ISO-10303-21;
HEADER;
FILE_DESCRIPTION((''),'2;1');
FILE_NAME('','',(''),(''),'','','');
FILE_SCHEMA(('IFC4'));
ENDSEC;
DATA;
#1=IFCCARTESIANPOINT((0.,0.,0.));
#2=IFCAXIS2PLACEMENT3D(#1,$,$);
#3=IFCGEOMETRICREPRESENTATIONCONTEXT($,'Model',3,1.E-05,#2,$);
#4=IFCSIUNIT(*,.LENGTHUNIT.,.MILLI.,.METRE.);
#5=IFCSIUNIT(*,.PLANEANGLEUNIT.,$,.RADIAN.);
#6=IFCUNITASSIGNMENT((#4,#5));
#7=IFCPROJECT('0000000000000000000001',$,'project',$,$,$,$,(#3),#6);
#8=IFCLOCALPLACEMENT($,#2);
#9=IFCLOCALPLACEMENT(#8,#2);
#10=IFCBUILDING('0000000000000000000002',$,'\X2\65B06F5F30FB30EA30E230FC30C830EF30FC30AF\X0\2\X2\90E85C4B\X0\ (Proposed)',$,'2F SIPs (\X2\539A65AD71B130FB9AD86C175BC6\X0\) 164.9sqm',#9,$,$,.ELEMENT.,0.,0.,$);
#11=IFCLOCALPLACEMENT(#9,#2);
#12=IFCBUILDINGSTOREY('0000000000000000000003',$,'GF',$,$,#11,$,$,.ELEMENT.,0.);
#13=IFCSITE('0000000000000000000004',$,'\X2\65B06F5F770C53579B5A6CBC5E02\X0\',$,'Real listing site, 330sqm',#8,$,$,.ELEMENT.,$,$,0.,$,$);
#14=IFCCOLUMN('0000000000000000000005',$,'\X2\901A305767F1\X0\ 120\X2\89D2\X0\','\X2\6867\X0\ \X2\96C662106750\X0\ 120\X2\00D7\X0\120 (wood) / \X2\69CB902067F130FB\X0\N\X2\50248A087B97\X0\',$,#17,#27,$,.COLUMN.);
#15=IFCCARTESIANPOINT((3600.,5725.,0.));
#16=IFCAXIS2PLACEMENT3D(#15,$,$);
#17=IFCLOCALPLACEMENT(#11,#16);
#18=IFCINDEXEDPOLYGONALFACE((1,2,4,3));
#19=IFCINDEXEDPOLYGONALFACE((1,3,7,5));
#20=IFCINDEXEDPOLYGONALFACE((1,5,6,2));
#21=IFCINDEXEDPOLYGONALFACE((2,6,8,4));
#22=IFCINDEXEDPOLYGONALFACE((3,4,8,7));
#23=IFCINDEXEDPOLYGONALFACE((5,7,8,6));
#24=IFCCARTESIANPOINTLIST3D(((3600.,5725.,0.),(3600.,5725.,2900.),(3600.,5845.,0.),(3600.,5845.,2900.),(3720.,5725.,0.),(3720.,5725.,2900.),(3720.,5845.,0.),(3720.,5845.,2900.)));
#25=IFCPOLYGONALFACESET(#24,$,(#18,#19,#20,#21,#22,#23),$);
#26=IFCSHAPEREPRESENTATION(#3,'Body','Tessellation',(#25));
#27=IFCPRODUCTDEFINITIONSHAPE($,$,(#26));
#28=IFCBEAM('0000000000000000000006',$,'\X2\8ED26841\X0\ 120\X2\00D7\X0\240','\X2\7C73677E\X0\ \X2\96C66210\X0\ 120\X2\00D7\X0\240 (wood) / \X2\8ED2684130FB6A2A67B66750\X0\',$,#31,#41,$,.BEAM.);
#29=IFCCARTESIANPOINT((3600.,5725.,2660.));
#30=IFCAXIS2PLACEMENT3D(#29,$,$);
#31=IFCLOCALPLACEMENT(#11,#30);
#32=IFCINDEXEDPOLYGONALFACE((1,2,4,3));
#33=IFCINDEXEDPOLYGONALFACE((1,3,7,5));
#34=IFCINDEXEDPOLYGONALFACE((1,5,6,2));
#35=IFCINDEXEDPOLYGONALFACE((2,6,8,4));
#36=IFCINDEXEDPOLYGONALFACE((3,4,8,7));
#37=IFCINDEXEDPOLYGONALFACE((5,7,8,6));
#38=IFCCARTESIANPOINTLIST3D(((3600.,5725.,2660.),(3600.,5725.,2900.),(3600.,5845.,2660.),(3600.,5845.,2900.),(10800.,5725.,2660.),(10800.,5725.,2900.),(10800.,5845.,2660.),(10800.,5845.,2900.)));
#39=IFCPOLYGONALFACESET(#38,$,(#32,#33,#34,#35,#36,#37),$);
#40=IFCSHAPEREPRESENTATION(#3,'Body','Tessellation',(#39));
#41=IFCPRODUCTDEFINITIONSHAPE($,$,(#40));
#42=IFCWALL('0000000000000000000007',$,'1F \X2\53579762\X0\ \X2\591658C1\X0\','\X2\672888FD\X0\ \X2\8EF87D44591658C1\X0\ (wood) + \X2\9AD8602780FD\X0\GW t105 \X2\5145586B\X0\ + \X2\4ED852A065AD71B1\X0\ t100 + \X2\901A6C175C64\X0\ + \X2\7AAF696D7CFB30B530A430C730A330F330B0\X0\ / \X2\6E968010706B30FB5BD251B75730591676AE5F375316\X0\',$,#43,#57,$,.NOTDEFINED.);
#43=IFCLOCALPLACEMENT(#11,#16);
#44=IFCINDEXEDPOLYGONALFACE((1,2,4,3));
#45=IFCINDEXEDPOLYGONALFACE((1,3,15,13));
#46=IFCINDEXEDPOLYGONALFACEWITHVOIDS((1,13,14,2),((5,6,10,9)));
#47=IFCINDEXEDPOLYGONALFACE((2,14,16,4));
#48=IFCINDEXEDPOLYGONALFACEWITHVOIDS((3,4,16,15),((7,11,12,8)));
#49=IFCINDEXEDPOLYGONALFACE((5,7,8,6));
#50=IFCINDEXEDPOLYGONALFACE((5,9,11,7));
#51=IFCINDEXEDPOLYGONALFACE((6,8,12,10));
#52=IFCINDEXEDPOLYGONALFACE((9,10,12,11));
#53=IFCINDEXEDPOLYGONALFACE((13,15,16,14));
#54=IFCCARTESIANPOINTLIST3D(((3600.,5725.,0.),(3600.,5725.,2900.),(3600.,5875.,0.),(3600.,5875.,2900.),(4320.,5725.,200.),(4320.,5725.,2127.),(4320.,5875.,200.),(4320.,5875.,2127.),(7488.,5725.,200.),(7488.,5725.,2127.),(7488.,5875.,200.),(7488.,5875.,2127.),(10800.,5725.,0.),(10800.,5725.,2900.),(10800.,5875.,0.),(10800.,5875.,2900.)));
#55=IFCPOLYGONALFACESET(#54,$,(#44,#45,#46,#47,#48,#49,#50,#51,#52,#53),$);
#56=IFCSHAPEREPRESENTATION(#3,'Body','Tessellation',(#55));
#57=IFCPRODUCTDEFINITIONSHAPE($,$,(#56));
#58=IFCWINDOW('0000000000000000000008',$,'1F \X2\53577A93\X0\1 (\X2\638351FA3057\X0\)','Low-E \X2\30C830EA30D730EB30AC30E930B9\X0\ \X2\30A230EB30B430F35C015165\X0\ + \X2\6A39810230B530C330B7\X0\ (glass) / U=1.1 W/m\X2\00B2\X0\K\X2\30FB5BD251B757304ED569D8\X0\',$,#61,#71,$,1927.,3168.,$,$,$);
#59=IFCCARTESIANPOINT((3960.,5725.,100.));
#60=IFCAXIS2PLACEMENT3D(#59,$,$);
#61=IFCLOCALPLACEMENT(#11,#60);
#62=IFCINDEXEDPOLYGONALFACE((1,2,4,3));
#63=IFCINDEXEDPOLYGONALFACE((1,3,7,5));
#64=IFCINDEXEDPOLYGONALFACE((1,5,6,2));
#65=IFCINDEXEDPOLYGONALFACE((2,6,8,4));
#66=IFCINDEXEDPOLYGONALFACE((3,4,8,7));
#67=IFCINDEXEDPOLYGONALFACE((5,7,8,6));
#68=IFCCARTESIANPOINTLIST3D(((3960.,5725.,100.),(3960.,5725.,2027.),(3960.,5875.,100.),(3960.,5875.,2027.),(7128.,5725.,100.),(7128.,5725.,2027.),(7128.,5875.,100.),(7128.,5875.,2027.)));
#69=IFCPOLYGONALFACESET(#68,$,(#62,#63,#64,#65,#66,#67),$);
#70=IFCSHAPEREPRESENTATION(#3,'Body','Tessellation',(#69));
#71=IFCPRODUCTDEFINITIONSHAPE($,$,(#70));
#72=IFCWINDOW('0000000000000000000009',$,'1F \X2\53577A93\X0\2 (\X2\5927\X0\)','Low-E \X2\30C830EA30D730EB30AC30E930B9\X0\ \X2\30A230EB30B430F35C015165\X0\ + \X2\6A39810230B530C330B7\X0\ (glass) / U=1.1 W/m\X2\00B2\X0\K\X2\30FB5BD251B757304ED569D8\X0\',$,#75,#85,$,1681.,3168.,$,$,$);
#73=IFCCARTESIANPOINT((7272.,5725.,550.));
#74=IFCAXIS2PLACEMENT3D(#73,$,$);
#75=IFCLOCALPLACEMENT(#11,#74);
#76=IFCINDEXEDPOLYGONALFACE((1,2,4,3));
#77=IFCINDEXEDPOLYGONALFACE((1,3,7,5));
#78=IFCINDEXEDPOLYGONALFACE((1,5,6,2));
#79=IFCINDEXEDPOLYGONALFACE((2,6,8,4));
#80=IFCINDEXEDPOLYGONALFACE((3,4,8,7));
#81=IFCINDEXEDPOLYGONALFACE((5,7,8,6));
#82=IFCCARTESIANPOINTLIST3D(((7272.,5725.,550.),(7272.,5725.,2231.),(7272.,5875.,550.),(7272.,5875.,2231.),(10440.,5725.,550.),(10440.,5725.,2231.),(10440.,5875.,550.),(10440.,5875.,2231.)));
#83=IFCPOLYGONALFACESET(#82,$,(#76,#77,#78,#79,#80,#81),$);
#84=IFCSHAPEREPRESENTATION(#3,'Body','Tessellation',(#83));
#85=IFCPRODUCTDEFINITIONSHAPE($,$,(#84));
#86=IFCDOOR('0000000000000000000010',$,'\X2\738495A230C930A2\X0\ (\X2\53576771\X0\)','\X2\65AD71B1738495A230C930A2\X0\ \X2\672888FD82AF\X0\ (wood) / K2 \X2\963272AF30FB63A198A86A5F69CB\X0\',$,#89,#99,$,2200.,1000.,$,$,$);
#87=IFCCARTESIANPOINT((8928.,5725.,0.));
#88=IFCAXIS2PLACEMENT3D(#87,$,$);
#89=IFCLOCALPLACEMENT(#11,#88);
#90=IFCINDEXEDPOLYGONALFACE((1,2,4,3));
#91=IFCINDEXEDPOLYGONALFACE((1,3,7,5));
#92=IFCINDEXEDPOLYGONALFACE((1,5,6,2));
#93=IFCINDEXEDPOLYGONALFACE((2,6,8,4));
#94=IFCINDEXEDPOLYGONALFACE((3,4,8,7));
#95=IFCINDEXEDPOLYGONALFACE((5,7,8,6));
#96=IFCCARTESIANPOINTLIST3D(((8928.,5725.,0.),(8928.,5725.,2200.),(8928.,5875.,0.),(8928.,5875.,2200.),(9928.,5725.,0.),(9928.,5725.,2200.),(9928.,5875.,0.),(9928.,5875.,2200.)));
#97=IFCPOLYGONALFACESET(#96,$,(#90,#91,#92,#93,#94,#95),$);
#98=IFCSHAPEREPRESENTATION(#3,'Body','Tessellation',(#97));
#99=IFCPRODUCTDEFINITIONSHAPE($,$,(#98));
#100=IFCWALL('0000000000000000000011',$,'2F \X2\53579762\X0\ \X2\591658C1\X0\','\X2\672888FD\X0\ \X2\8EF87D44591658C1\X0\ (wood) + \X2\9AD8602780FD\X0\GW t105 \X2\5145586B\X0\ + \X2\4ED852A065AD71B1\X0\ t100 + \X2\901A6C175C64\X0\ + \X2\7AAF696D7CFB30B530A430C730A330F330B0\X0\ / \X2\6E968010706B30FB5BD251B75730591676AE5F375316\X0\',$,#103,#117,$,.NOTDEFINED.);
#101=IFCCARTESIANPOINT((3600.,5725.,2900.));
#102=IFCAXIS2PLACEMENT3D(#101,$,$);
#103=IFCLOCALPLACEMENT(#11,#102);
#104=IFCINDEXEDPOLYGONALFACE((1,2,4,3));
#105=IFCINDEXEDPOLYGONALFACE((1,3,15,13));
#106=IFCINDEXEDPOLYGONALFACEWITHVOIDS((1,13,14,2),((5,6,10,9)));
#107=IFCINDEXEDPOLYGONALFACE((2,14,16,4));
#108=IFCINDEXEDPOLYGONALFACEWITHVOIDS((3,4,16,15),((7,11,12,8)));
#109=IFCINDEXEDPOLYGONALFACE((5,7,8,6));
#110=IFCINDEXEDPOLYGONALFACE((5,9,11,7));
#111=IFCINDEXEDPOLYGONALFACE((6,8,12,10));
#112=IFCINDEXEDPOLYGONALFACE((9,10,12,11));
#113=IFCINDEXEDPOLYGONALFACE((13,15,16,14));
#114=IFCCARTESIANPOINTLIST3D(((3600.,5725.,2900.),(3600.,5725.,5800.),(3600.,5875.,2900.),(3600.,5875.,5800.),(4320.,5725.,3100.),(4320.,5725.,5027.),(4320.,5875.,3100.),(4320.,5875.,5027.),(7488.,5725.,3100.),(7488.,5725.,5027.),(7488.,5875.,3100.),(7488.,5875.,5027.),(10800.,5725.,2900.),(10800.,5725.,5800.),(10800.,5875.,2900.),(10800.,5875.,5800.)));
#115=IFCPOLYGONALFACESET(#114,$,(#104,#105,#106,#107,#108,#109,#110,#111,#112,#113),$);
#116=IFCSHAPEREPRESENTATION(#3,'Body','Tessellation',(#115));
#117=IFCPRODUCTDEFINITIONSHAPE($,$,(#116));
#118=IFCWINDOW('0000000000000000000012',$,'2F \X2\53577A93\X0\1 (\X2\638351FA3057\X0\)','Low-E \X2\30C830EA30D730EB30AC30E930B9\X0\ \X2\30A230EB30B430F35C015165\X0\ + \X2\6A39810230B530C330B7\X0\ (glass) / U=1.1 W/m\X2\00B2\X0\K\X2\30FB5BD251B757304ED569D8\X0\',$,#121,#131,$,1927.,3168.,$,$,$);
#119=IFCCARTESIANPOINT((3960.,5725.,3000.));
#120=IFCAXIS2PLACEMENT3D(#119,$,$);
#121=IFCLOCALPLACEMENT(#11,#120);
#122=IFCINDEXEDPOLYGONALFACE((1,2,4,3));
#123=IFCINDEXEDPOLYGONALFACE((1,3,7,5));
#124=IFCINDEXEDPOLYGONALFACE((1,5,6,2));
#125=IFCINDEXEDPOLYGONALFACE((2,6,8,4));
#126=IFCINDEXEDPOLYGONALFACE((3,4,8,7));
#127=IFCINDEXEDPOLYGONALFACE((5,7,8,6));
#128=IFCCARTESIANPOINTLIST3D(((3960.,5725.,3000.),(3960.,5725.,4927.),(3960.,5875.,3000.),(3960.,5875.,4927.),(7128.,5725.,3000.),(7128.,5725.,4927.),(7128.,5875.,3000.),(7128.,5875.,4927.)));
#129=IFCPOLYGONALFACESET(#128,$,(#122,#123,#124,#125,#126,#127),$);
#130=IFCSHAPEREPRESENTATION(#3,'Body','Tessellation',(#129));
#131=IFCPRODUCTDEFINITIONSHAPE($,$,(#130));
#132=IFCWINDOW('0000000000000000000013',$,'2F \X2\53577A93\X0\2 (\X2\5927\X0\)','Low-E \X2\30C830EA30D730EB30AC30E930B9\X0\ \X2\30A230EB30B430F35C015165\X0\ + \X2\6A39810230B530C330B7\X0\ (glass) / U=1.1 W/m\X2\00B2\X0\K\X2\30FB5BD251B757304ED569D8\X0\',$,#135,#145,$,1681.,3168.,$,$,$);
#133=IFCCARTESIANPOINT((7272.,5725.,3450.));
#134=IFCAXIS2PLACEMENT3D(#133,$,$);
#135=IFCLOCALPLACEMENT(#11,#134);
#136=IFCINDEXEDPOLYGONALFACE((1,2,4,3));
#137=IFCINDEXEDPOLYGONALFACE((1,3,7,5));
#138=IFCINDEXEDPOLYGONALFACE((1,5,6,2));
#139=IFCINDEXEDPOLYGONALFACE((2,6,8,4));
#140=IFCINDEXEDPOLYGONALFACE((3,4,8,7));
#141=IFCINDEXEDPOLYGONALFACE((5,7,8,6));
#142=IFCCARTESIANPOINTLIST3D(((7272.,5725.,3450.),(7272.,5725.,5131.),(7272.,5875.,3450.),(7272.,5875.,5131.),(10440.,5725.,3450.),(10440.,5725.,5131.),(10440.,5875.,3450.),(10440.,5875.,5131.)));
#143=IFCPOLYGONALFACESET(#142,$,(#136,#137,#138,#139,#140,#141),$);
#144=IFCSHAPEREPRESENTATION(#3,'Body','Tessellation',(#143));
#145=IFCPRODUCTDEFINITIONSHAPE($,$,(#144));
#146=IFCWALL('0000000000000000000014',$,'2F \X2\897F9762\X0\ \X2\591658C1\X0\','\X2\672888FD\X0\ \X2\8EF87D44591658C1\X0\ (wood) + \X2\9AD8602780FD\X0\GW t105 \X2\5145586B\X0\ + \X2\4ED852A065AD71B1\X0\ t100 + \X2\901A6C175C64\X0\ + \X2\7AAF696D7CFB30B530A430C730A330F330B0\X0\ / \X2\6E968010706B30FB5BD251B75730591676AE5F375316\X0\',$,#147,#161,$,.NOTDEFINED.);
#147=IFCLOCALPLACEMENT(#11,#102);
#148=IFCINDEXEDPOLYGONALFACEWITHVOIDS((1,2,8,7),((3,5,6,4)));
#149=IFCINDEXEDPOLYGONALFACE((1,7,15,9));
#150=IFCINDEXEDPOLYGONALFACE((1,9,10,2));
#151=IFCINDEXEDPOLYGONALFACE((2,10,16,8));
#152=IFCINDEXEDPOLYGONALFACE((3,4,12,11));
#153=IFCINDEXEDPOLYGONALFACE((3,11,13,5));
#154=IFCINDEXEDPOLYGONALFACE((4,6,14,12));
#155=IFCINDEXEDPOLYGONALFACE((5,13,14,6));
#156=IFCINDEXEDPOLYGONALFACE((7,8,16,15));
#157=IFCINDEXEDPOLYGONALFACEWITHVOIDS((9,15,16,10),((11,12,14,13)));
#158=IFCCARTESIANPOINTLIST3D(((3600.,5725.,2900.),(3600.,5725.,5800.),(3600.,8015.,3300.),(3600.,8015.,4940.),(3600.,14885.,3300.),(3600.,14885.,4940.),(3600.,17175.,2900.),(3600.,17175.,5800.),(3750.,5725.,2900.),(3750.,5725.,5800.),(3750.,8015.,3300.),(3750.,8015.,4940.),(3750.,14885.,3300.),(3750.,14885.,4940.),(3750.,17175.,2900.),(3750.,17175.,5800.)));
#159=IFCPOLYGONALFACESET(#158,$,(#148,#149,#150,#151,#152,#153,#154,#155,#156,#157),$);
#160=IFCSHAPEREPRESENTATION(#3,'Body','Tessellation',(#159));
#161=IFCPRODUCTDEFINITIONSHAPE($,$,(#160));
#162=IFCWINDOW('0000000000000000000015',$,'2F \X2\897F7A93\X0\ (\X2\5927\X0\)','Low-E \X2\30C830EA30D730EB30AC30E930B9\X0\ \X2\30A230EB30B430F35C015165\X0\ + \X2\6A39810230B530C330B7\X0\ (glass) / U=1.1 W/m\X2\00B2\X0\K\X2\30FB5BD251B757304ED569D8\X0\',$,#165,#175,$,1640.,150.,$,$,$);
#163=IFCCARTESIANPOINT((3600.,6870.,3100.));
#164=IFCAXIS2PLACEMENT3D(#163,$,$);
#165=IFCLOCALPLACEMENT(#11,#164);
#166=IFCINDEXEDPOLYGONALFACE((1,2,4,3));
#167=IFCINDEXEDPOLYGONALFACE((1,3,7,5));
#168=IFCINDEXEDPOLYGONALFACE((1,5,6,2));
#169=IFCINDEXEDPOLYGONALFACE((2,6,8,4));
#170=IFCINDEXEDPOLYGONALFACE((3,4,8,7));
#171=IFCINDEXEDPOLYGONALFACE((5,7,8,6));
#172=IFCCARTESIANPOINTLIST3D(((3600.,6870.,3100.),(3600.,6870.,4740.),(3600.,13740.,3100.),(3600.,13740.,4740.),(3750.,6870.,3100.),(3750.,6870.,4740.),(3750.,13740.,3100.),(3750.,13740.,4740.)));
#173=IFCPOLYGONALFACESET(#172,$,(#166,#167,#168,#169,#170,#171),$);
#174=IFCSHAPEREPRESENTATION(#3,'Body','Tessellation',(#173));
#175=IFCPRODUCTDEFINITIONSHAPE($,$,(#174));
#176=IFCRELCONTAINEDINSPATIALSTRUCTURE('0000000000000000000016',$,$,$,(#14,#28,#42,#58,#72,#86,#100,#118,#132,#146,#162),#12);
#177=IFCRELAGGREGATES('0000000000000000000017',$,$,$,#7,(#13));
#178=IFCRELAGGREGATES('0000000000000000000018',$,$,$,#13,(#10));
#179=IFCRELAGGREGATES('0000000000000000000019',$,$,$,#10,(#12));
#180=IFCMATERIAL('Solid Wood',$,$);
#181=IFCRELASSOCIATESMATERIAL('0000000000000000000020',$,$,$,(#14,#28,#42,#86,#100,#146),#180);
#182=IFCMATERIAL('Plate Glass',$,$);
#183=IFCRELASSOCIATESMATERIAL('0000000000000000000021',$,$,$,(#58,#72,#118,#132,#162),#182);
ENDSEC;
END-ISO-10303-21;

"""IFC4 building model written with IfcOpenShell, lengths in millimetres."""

from ifc_helpers import new_model, si_unit, frame, frame_2d, origin, place, context, project, spatial, rectangle, extrude, material, element, fill, save


model = new_model("IFC4")

# Units and contexts
model_context = context("Model", 3, precision=1e-05, world=origin())
ifc_project = project(units=[si_unit("LENGTHUNIT", "METRE", prefix="MILLI"), si_unit("PLANEANGLEUNIT", "RADIAN")], contexts=[model_context])

# Site, building, storey
site_placement = place(None, origin())
site = spatial("IfcSite", under=ifc_project, at=site_placement, Name="新潟県南魚沼市", ObjectType="Real listing site, 330sqm", CompositionType="ELEMENT", RefElevation=0.0)
building_placement = place(site_placement, origin())
building = spatial("IfcBuilding", under=site, at=building_placement, Name="新潟・リモートワーク2部屋 (Proposed)", ObjectType="2F SIPs (厚断熱・高気密) 164.9sqm", CompositionType="ELEMENT", ElevationOfRefHeight=0.0, ElevationOfTerrain=0.0)
storey_placement = place(building_placement, origin())
storey = spatial("IfcBuildingStorey", under=building, at=storey_placement, Name="GF", CompositionType="ELEMENT", Elevation=0.0)

# Column
ifc_material_1 = material(Name="Solid Wood")
column_placement = place(storey_placement, frame((3600.0, 5725.0, 0.0)))
element("IfcColumn", 1, at=column_placement, inside=storey, material=ifc_material_1, Name="通し柱 120角", Description="桧 集成材 120×120 (wood) / 構造柱・N値計算", PredefinedType="COLUMN", context=model_context, shape_type="SweptSolid", body=[
    extrude(rectangle(XDim=120.0, YDim=120.0, at=frame_2d((60.0, 60.0))), frame((3600.0, 5725.0, 0.0)), (0.0, 0.0, 1.0), 2900.0),
])

# Beam
beam_1_placement = place(storey_placement, frame((3600.0, 5725.0, 2660.0)))
element("IfcBeam", 2, at=beam_1_placement, inside=storey, material=ifc_material_1, Name="軒桁 120×240", Description="米松 集成 120×240 (wood) / 軒桁・横架材", PredefinedType="BEAM", context=model_context, shape_type="SweptSolid", body=[
    extrude(rectangle(XDim=7200.0, YDim=120.0, at=frame_2d((3600.0, 60.0))), frame((3600.0, 5725.0, 2660.0)), (0.0, 0.0, 1.0), 240.0),
])

# Wall, openings, windows, door
wall_1_placement = place(storey_placement, frame((3600.0, 5725.0, 0.0)))
wall_1 = element("IfcWall", 3, at=wall_1_placement, inside=storey, material=ifc_material_1, Name="1F 南面 外壁", Description="木製 軸組外壁 (wood) + 高性能GW t105 充填 + 付加断熱 t100 + 通気層 + 窯業系サイディング / 準耐火・寒冷地外皮強化", PredefinedType="NOTDEFINED", context=model_context, shape_type="SweptSolid", body=[
    extrude(rectangle(XDim=7200.0, YDim=150.0, at=frame_2d((3600.0, 75.0))), frame((3600.0, 5725.0, 0.0)), (0.0, 0.0, 1.0), 2900.0),
])
opening_1_placement = place(storey_placement, frame((3960.0, 5725.0, 100.0)))
opening_1 = element("IfcOpeningElement", 4, at=opening_1_placement, cuts=wall_1, PredefinedType="NOTDEFINED", context=model_context, shape_type="SweptSolid", body=[
    extrude(rectangle(XDim=3168.0, YDim=150.0, at=frame_2d((1584.0, 75.0))), frame((3960.0, 5725.0, 100.0)), (0.0, 0.0, 1.0), 1927.0),
])
opening_2_placement = place(storey_placement, frame((7272.0, 5725.0, 550.0)))
opening_2 = element("IfcOpeningElement", 5, at=opening_2_placement, cuts=wall_1, PredefinedType="NOTDEFINED", context=model_context, shape_type="SweptSolid", body=[
    extrude(rectangle(XDim=3168.0, YDim=150.0, at=frame_2d((1584.0, 75.0))), frame((7272.0, 5725.0, 550.0)), (0.0, 0.0, 1.0), 1681.0),
])
opening_3_placement = place(storey_placement, frame((8928.0, 5725.0, 0.0)))
opening_3 = element("IfcOpeningElement", 6, at=opening_3_placement, cuts=wall_1, PredefinedType="NOTDEFINED", context=model_context, shape_type="SweptSolid", body=[
    extrude(rectangle(XDim=1000.0, YDim=150.0, at=frame_2d((500.0, 75.0))), frame((8928.0, 5725.0, 0.0)), (0.0, 0.0, 1.0), 2200.0),
])
ifc_material_2 = material(Name="Plate Glass")
window_1_placement = place(storey_placement, frame((3960.0, 5725.0, 100.0)))
window_1 = element("IfcWindow", 7, at=window_1_placement, inside=storey, material=ifc_material_2, Name="1F 南窓1 (掃出し)", Description="Low-E トリプルガラス アルゴン封入 + 樹脂サッシ (glass) / U=1.1 W/m²K・寒冷地仕様", OverallHeight=1927.0, OverallWidth=3168.0, context=model_context, shape_type="SweptSolid", body=[
    extrude(rectangle(XDim=3168.0, YDim=150.0, at=frame_2d((1584.0, 75.0))), frame((3960.0, 5725.0, 100.0)), (0.0, 0.0, 1.0), 1927.0),
])
fill(opening_1, window_1)
window_2_placement = place(storey_placement, frame((7272.0, 5725.0, 550.0)))
window_2 = element("IfcWindow", 8, at=window_2_placement, inside=storey, material=ifc_material_2, Name="1F 南窓2 (大)", Description="Low-E トリプルガラス アルゴン封入 + 樹脂サッシ (glass) / U=1.1 W/m²K・寒冷地仕様", OverallHeight=1681.0, OverallWidth=3168.0, context=model_context, shape_type="SweptSolid", body=[
    extrude(rectangle(XDim=3168.0, YDim=150.0, at=frame_2d((1584.0, 75.0))), frame((7272.0, 5725.0, 550.0)), (0.0, 0.0, 1.0), 1681.0),
])
fill(opening_2, window_2)
door_placement = place(storey_placement, frame((8928.0, 5725.0, 0.0)))
door = element("IfcDoor", 9, at=door_placement, inside=storey, material=ifc_material_1, Name="玄関ドア (南東)", Description="断熱玄関ドア 木製芯 (wood) / K2 防犯・採風機構", OverallHeight=2200.0, OverallWidth=1000.0, context=model_context, shape_type="SweptSolid", body=[
    extrude(rectangle(XDim=1000.0, YDim=150.0, at=frame_2d((500.0, 75.0))), frame((8928.0, 5725.0, 0.0)), (0.0, 0.0, 1.0), 2200.0),
])
fill(opening_3, door)

# Wall, openings, windows
wall_2_placement = place(storey_placement, frame((3600.0, 5725.0, 2900.0)))
wall_2 = element("IfcWall", 10, at=wall_2_placement, inside=storey, material=ifc_material_1, Name="2F 南面 外壁", Description="木製 軸組外壁 (wood) + 高性能GW t105 充填 + 付加断熱 t100 + 通気層 + 窯業系サイディング / 準耐火・寒冷地外皮強化", PredefinedType="NOTDEFINED", context=model_context, shape_type="SweptSolid", body=[
    extrude(rectangle(XDim=7200.0, YDim=150.0, at=frame_2d((3600.0, 75.0))), frame((3600.0, 5725.0, 2900.0)), (0.0, 0.0, 1.0), 2900.0),
])
opening_4_placement = place(storey_placement, frame((3960.0, 5725.0, 3000.0)))
opening_4 = element("IfcOpeningElement", 11, at=opening_4_placement, cuts=wall_2, PredefinedType="NOTDEFINED", context=model_context, shape_type="SweptSolid", body=[
    extrude(rectangle(XDim=3168.0, YDim=150.0, at=frame_2d((1584.0, 75.0))), frame((3960.0, 5725.0, 3000.0)), (0.0, 0.0, 1.0), 1927.0),
])
opening_5_placement = place(storey_placement, frame((7272.0, 5725.0, 3450.0)))
opening_5 = element("IfcOpeningElement", 12, at=opening_5_placement, cuts=wall_2, PredefinedType="NOTDEFINED", context=model_context, shape_type="SweptSolid", body=[
    extrude(rectangle(XDim=3168.0, YDim=150.0, at=frame_2d((1584.0, 75.0))), frame((7272.0, 5725.0, 3450.0)), (0.0, 0.0, 1.0), 1681.0),
])
window_3_placement = place(storey_placement, frame((3960.0, 5725.0, 3000.0)))
window_3 = element("IfcWindow", 13, at=window_3_placement, inside=storey, material=ifc_material_2, Name="2F 南窓1 (掃出し)", Description="Low-E トリプルガラス アルゴン封入 + 樹脂サッシ (glass) / U=1.1 W/m²K・寒冷地仕様", OverallHeight=1927.0, OverallWidth=3168.0, context=model_context, shape_type="SweptSolid", body=[
    extrude(rectangle(XDim=3168.0, YDim=150.0, at=frame_2d((1584.0, 75.0))), frame((3960.0, 5725.0, 3000.0)), (0.0, 0.0, 1.0), 1927.0),
])
fill(opening_4, window_3)
window_4_placement = place(storey_placement, frame((7272.0, 5725.0, 3450.0)))
window_4 = element("IfcWindow", 14, at=window_4_placement, inside=storey, material=ifc_material_2, Name="2F 南窓2 (大)", Description="Low-E トリプルガラス アルゴン封入 + 樹脂サッシ (glass) / U=1.1 W/m²K・寒冷地仕様", OverallHeight=1681.0, OverallWidth=3168.0, context=model_context, shape_type="SweptSolid", body=[
    extrude(rectangle(XDim=3168.0, YDim=150.0, at=frame_2d((1584.0, 75.0))), frame((7272.0, 5725.0, 3450.0)), (0.0, 0.0, 1.0), 1681.0),
])
fill(opening_5, window_4)

# Wall, opening, window
wall_3_placement = place(storey_placement, frame((3600.0, 5725.0, 2900.0)))
wall_3 = element("IfcWall", 15, at=wall_3_placement, inside=storey, material=ifc_material_1, Name="2F 西面 外壁", Description="木製 軸組外壁 (wood) + 高性能GW t105 充填 + 付加断熱 t100 + 通気層 + 窯業系サイディング / 準耐火・寒冷地外皮強化", PredefinedType="NOTDEFINED", context=model_context, shape_type="SweptSolid", body=[
    extrude(rectangle(XDim=150.0, YDim=11450.0, at=frame_2d((75.0, 5725.0))), frame((3600.0, 5725.0, 2900.0)), (0.0, 0.0, 1.0), 2900.0),
])
opening_6_placement = place(storey_placement, frame((3600.0, 6870.0, 3100.0)))
opening_6 = element("IfcOpeningElement", 16, at=opening_6_placement, cuts=wall_3, PredefinedType="NOTDEFINED", context=model_context, shape_type="SweptSolid", body=[
    extrude(rectangle(XDim=150.0, YDim=6870.0, at=frame_2d((75.0, 3435.0))), frame((3600.0, 6870.0, 3100.0)), (0.0, 0.0, 1.0), 1640.0),
])
window_5_placement = place(storey_placement, frame((3600.0, 6870.0, 3100.0)))
window_5 = element("IfcWindow", 17, at=window_5_placement, inside=storey, material=ifc_material_2, Name="2F 西窓 (大)", Description="Low-E トリプルガラス アルゴン封入 + 樹脂サッシ (glass) / U=1.1 W/m²K・寒冷地仕様", OverallHeight=1640.0, OverallWidth=150.0, context=model_context, shape_type="SweptSolid", body=[
    extrude(rectangle(XDim=150.0, YDim=6870.0, at=frame_2d((75.0, 3435.0))), frame((3600.0, 6870.0, 3100.0)), (0.0, 0.0, 1.0), 1640.0),
])
fill(opening_6, window_5)

save(model, "model.ifc")
